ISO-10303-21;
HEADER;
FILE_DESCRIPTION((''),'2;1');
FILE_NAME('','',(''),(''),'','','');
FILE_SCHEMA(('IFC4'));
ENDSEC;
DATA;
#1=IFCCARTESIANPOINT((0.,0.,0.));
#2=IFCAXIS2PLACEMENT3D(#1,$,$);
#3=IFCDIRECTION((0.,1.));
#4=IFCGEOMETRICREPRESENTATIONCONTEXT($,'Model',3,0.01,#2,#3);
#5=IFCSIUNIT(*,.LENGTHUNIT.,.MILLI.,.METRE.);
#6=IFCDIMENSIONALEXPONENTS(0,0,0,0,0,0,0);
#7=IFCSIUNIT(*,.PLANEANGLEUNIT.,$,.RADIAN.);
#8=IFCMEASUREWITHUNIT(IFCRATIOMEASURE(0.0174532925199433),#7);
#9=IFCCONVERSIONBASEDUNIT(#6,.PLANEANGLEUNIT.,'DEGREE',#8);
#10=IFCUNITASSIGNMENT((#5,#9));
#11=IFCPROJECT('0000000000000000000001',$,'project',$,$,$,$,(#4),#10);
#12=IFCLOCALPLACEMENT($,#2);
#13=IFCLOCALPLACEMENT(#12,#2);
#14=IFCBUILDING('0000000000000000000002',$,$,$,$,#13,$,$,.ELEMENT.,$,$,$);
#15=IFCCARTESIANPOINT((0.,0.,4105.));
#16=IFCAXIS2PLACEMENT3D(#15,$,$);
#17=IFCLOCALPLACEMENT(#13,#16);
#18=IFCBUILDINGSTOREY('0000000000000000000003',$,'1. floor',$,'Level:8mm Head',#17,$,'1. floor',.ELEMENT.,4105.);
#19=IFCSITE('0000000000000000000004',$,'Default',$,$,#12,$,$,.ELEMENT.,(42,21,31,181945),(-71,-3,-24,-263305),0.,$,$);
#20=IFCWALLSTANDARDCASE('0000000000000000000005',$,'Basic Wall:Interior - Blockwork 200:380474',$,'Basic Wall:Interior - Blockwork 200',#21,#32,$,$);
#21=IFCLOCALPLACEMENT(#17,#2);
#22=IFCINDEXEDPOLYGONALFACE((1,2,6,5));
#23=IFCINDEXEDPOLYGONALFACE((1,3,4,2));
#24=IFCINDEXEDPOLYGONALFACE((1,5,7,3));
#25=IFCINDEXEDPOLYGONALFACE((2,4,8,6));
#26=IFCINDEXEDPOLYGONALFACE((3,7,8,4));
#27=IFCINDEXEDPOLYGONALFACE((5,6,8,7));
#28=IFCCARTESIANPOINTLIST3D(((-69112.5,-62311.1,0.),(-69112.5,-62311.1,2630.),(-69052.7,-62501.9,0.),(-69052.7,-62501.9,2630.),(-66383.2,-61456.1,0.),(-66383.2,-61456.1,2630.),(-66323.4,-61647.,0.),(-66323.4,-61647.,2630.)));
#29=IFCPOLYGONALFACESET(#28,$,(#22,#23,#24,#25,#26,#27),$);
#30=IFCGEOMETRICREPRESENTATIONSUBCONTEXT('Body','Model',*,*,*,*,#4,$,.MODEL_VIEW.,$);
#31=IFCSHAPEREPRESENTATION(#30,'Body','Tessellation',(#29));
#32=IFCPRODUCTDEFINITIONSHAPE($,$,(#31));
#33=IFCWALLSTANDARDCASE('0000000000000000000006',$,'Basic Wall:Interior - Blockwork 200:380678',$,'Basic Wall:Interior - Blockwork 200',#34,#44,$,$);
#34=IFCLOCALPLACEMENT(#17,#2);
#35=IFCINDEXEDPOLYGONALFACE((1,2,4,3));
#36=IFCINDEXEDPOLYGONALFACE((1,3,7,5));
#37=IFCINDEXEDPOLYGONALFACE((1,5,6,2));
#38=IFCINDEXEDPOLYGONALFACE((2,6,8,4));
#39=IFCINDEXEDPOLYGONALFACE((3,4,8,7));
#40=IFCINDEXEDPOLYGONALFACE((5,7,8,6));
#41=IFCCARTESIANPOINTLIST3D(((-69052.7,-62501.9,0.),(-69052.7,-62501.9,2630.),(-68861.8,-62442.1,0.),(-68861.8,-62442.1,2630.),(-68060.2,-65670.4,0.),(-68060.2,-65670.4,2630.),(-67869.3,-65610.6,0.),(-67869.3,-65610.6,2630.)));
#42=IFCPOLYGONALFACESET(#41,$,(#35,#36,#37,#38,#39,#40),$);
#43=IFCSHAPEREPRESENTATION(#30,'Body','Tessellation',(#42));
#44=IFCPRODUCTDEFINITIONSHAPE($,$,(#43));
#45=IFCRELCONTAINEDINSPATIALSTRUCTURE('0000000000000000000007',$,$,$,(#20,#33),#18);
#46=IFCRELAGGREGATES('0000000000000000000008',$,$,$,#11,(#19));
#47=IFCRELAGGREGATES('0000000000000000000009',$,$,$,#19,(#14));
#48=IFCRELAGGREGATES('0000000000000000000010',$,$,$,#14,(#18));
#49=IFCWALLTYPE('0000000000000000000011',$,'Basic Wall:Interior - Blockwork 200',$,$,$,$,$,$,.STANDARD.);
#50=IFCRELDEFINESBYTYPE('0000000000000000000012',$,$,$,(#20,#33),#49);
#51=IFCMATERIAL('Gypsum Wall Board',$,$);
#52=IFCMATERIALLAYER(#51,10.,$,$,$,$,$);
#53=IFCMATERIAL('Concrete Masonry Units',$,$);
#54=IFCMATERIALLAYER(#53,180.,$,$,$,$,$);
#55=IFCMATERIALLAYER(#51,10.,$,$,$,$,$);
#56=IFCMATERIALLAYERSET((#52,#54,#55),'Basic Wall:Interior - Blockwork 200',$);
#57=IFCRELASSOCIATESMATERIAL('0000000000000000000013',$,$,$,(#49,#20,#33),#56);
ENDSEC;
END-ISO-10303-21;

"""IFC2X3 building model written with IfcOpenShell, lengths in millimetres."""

from ifc_helpers import new_model, entity, si_unit, converted_unit, direction, frame, frame_2d, origin, place, context, subcontext, project, spatial, rectangle, extrude, material, layer, layer_set, layer_usage, type_object, element, save


model = new_model("IFC2X3")

# Units and contexts
model_context = context("Model", 3, precision=0.01, world=origin(), true_north=direction((0.0, 1.0)))
body_context = subcontext(model_context, "Body", "Model", "MODEL_VIEW")
ifc_project = project(units=[si_unit("LENGTHUNIT", "METRE", prefix="MILLI"), converted_unit("PLANEANGLEUNIT", "DEGREE", entity("IfcRatioMeasure", 0.0174532925199433), si_unit("PLANEANGLEUNIT", "RADIAN"), dimensions=[0, 0, 0, 0, 0, 0, 0])], contexts=[model_context])

# Site, building, storey
site_placement = place(None, origin())
site = spatial("IfcSite", under=ifc_project, at=site_placement, Name="Default", CompositionType="ELEMENT", RefLatitude=(42, 21, 31, 181945), RefLongitude=(-71, -3, -24, -263305), RefElevation=0.0)
building_placement = place(site_placement, origin())
building = spatial("IfcBuilding", under=site, at=building_placement, CompositionType="ELEMENT")
storey_placement = place(building_placement, frame((0.0, 0.0, 4105.0)))
storey = spatial("IfcBuildingStorey", under=building, at=storey_placement, Name="1. floor", ObjectType="Level:8mm Head", LongName="1. floor", CompositionType="ELEMENT", Elevation=4105.0)

# Shared definitions
ifc_material_1 = material(Name="Gypsum Wall Board")
ifc_material_2 = material(Name="Concrete Masonry Units")

# Walls
ifc_layer_1 = layer(ifc_material_1, 10.0)
ifc_layer_2 = layer(ifc_material_2, 180.0)
ifc_layer_3 = layer(ifc_material_1, 10.0)
ifc_layer_set_1 = layer_set([ifc_layer_1, ifc_layer_2, ifc_layer_3], Name="Basic Wall:Interior - Blockwork 200")
ifc_layer_usage_1 = layer_usage(ifc_layer_set_1, "AXIS2", "NEGATIVE", 100.0)
wall_type_1 = type_object("IfcWallType", Name="Basic Wall:Interior - Blockwork 200", PredefinedType="STANDARD", material=ifc_layer_set_1)
wall_1_placement = place(storey_placement, frame((-69082.6, -62406.5, 0.0), z_axis=(0.0, 0.0, 1.0), x_axis=(0.954277, 0.298924, 0.0)))
element("IfcWallStandardCase", 1, at=wall_1_placement, inside=storey, type_object=wall_type_1, material=ifc_layer_usage_1, Name="Basic Wall:Interior - Blockwork 200:380474", ObjectType="Basic Wall:Interior - Blockwork 200", context=body_context, shape_type="SweptSolid", body=[
    extrude(rectangle(XDim=2860.0, YDim=200.0, at=frame_2d((1430.0, 0.0), x_axis=(-1.0, 0.0))), origin(), (0.0, 0.0, 1.0), 2630.0),
])
ifc_layer_usage_2 = layer_usage(ifc_layer_set_1, "AXIS2", "NEGATIVE", 100.0)
wall_2_placement = place(storey_placement, frame((-68957.2, -62472.0, 0.0), z_axis=(0.0, 0.0, 1.0), x_axis=(0.298924, -0.954277, 0.0)))
element("IfcWallStandardCase", 2, at=wall_2_placement, inside=storey, type_object=wall_type_1, material=ifc_layer_usage_2, Name="Basic Wall:Interior - Blockwork 200:380678", ObjectType="Basic Wall:Interior - Blockwork 200", context=body_context, shape_type="SweptSolid", body=[
    extrude(rectangle(XDim=3320.3, YDim=200.0, at=frame_2d((1660.1, 0.0), x_axis=(-1.0, 0.0))), origin(), (0.0, 0.0, 1.0), 2630.0),
])

save(model, "model.ifc")
